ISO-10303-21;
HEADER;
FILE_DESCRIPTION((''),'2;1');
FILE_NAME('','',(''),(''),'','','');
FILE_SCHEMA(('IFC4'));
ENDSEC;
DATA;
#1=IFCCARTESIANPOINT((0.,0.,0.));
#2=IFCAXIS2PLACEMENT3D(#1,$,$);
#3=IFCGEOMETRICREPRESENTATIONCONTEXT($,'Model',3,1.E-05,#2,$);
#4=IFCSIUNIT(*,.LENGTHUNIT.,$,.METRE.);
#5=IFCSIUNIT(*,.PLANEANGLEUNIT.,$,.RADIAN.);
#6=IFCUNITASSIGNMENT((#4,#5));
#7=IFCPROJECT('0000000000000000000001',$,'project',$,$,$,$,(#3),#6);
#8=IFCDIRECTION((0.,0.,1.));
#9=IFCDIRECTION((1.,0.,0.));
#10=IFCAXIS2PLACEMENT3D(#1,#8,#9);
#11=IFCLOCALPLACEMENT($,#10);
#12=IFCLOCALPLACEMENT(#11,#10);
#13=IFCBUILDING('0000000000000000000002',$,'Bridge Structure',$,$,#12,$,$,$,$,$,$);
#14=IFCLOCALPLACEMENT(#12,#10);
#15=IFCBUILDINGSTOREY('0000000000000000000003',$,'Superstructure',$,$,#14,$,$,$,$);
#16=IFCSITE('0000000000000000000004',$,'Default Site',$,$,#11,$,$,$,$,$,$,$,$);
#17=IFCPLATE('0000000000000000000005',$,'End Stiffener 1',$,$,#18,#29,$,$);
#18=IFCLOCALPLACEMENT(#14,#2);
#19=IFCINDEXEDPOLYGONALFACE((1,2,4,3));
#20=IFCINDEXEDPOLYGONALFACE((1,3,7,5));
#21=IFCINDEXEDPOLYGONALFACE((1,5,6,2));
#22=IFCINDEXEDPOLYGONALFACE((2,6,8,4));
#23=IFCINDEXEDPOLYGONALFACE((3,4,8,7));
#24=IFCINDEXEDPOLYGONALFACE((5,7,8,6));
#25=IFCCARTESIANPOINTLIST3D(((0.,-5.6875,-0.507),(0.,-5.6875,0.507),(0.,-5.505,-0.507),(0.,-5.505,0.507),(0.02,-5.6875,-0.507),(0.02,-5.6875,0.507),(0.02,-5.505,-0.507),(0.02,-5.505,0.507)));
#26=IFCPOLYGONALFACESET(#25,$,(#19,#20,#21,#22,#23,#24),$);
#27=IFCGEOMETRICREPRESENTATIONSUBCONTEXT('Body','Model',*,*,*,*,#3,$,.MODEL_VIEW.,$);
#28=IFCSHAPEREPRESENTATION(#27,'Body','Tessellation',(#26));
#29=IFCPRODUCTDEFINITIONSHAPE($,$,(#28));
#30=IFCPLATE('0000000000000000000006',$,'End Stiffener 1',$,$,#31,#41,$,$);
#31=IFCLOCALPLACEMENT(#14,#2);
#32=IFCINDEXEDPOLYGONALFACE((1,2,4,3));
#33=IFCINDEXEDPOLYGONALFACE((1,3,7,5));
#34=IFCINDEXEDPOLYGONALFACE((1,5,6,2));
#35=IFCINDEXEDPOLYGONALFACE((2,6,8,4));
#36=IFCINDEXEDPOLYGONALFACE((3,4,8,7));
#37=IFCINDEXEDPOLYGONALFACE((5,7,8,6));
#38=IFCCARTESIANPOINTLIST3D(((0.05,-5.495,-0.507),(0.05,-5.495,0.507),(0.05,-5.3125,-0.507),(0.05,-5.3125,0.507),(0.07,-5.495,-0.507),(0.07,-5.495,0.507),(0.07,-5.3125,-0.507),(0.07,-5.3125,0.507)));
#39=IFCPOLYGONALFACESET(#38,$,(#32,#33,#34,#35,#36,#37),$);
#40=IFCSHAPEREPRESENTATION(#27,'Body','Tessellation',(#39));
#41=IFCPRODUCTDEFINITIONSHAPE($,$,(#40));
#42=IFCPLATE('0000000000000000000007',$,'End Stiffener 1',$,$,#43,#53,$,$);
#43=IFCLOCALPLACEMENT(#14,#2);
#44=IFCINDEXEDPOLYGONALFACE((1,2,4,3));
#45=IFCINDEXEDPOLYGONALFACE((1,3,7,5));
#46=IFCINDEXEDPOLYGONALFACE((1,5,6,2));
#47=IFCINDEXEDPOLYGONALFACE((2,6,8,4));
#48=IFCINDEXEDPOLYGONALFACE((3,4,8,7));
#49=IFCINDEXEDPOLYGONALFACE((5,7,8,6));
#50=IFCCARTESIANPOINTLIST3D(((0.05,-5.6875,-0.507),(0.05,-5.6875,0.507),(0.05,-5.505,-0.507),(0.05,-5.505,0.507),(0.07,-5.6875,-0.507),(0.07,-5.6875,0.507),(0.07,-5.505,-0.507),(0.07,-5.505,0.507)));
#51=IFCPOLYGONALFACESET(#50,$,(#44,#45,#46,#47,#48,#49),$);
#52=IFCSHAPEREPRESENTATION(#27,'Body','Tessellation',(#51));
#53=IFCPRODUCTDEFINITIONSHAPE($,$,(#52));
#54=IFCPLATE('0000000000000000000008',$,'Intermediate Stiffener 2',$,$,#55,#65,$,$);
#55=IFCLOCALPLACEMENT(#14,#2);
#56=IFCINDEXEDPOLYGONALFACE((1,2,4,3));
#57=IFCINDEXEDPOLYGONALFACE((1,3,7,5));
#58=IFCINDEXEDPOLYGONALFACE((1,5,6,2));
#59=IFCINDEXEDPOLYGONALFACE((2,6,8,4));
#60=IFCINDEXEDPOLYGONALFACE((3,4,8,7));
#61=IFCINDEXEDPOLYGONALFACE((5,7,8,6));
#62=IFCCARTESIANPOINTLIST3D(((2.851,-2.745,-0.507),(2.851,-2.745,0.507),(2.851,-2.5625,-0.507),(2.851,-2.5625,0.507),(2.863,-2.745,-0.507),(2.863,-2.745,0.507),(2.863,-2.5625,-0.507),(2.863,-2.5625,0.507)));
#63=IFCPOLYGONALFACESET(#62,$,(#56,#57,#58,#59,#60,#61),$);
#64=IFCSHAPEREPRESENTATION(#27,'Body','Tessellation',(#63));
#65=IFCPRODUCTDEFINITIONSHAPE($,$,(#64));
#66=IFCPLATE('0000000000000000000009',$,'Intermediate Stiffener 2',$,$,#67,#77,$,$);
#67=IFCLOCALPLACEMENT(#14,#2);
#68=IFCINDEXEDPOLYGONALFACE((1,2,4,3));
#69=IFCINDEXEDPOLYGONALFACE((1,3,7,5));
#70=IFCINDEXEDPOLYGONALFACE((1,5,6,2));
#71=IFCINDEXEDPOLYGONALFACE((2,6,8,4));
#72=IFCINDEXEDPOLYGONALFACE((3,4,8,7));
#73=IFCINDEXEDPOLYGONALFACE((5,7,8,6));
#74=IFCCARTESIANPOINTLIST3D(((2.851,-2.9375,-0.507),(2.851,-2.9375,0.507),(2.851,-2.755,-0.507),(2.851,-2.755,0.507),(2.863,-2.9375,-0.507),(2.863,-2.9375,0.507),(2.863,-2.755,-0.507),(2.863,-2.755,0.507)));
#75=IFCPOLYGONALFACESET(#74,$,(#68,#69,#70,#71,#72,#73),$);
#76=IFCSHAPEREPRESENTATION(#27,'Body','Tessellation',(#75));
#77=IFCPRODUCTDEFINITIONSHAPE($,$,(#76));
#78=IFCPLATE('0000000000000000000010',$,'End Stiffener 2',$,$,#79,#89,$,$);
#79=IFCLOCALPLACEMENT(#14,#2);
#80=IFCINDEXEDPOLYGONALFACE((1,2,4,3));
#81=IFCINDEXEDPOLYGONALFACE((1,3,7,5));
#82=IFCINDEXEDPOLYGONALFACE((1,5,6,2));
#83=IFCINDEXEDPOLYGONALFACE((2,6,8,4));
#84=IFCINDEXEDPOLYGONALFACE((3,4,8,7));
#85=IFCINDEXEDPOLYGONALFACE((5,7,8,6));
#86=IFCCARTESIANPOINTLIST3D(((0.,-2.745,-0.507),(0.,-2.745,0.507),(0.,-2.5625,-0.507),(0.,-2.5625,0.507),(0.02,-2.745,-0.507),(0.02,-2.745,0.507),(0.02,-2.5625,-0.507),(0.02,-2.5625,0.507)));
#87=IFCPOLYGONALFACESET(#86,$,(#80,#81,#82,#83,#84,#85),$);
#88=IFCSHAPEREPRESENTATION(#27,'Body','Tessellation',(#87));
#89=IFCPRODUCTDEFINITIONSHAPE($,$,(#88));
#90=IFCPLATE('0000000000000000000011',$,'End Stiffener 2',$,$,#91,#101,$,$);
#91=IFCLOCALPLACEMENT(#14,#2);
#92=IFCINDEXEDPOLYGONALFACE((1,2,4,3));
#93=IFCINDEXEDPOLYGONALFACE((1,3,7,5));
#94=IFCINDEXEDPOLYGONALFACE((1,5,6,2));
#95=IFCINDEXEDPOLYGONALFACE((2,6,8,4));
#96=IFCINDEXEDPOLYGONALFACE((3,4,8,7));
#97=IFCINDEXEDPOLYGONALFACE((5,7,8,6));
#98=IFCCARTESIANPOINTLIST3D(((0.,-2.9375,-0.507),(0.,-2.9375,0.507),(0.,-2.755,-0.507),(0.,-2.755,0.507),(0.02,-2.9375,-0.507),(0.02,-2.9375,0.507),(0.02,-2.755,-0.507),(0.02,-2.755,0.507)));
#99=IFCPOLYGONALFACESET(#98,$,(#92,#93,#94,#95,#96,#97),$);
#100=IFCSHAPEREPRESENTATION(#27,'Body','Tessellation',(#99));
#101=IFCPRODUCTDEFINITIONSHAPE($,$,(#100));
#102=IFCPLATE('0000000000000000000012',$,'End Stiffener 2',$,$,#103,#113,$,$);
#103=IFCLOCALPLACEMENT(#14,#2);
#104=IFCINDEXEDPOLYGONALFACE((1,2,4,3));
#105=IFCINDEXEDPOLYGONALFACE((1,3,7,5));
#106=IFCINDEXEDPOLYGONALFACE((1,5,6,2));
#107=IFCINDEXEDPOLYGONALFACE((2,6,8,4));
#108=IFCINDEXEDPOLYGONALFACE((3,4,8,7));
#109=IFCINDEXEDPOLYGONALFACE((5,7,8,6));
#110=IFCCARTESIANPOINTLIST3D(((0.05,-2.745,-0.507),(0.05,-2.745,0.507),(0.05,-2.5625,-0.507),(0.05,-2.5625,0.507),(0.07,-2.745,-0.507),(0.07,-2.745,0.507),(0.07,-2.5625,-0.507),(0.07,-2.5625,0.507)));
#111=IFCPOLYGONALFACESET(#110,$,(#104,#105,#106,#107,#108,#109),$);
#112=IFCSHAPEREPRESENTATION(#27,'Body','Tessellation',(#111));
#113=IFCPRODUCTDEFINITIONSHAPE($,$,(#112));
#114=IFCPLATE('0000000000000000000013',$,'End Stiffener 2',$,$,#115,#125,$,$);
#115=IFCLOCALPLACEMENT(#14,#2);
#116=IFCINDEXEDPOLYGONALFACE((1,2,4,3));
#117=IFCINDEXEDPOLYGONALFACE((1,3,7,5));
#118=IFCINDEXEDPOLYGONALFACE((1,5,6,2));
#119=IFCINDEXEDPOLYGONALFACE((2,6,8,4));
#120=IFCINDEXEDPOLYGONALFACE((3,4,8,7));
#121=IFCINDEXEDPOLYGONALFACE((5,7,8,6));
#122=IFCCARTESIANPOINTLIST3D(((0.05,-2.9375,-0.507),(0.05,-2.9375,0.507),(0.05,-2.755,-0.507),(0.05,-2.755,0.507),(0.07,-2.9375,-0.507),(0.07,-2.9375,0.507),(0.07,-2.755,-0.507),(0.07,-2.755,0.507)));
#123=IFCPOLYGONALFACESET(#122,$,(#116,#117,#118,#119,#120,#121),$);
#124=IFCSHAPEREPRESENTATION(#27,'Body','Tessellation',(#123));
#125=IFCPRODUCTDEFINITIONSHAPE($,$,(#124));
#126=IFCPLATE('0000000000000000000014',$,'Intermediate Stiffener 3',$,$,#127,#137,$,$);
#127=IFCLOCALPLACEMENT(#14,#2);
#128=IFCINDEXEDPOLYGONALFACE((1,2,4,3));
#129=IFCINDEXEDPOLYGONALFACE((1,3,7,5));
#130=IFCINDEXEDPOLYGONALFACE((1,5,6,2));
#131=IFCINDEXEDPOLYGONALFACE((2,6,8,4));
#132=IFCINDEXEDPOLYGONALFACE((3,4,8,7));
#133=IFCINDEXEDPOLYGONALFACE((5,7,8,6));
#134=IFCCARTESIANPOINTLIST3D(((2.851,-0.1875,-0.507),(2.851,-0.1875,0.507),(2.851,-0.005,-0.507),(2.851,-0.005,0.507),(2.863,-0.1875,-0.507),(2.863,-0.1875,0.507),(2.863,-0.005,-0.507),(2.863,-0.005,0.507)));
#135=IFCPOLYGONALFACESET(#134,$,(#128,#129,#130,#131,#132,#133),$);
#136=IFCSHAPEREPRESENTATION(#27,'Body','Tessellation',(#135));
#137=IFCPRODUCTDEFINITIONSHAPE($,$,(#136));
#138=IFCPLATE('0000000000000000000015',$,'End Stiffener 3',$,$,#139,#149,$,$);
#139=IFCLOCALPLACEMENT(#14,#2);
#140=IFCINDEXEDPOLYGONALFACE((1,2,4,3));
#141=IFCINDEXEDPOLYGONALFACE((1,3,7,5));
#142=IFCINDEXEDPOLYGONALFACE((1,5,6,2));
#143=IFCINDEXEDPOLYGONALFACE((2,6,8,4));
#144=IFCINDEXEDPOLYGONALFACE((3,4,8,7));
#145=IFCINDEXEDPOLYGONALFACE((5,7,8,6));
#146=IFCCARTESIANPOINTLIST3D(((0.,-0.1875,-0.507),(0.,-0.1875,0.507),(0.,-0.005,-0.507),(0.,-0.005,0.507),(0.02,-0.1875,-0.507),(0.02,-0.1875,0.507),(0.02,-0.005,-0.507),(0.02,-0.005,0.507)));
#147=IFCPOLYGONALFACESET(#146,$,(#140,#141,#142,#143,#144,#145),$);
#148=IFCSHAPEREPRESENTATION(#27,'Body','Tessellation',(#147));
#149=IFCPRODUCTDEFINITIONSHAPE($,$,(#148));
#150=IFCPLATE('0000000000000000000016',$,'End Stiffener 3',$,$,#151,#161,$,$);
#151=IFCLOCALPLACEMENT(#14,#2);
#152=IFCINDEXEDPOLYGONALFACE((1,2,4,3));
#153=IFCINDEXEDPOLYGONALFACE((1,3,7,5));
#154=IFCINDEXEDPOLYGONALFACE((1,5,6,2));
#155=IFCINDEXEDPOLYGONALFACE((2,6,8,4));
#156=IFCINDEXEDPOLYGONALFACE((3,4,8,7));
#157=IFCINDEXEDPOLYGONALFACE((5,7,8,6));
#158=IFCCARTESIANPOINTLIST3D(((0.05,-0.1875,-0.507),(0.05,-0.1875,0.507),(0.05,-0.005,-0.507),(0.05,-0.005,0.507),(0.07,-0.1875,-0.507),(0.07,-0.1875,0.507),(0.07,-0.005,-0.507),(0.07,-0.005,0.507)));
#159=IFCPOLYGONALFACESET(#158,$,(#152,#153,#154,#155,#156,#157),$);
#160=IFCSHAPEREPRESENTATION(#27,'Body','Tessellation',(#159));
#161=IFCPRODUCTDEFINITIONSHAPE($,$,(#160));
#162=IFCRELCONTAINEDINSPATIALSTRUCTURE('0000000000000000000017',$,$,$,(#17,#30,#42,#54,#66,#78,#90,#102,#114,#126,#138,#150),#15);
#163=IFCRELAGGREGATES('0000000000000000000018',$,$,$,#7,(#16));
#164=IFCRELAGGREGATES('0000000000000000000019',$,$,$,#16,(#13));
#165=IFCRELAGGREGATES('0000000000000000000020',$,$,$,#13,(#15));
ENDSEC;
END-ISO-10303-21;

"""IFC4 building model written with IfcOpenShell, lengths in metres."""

from ifc_helpers import new_model, si_unit, frame, origin, origin_with_axes, origin_2d_with_axis, place, context, subcontext, project, spatial, rectangle, extrude, element, save


model = new_model("IFC4")

# Units and contexts
model_context = context("Model", 3, precision=1e-05, world=origin())
body_context = subcontext(model_context, "Body", "Model", "MODEL_VIEW")
ifc_project = project(units=[si_unit("LENGTHUNIT", "METRE"), si_unit("PLANEANGLEUNIT", "RADIAN")], contexts=[model_context])

# Site, building, storey
site_placement = place(None, origin_with_axes())
site = spatial("IfcSite", under=ifc_project, at=site_placement, Name="Default Site")
building_placement = place(site_placement, origin_with_axes())
building = spatial("IfcBuilding", under=site, at=building_placement, Name="Bridge Structure")
storey_placement = place(building_placement, origin_with_axes())
storey = spatial("IfcBuildingStorey", under=building, at=storey_placement, Name="Superstructure")

# Plates
for number, where, z_axis, x_axis, name in (
    (1, (0.01, -5.5963, -0.507), (0.0, 0.0, 1.0), (1.0, 0.0, 0.0), "End Stiffener 1"),
    (2, (0.06, -5.4038, -0.507), (0.0, 0.0, 1.0), (1.0, 0.0, 0.0), "End Stiffener 1"),
    (3, (0.06, -5.5963, -0.507), (0.0, 0.0, 1.0), (1.0, 0.0, 0.0), "End Stiffener 1"),
):
    element("IfcPlate", number, at=place(storey_placement, frame(where, z_axis=z_axis, x_axis=x_axis)), inside=storey, Name=name, context=body_context, shape_type="SweptSolid", body=[
        extrude(rectangle(XDim=0.02, YDim=0.1825, at=origin_2d_with_axis()), origin_with_axes(), (0.0, 0.0, 1.0), 1.014),
    ])
for number, where, z_axis, x_axis, name in (
    (4, (2.857, -2.6538, -0.507), (0.0, 0.0, 1.0), (1.0, 0.0, 0.0), "Intermediate Stiffener 2"),
    (5, (2.857, -2.8462, -0.507), (0.0, 0.0, 1.0), (1.0, 0.0, 0.0), "Intermediate Stiffener 2"),
):
    element("IfcPlate", number, at=place(storey_placement, frame(where, z_axis=z_axis, x_axis=x_axis)), inside=storey, Name=name, context=body_context, shape_type="SweptSolid", body=[
        extrude(rectangle(XDim=0.012, YDim=0.1825, at=origin_2d_with_axis()), origin_with_axes(), (0.0, 0.0, 1.0), 1.014),
    ])
for number, where, z_axis, x_axis, name in (
    (6, (0.01, -2.6538, -0.507), (0.0, 0.0, 1.0), (1.0, 0.0, 0.0), "End Stiffener 2"),
    (7, (0.01, -2.8462, -0.507), (0.0, 0.0, 1.0), (1.0, 0.0, 0.0), "End Stiffener 2"),
    (8, (0.06, -2.6538, -0.507), (0.0, 0.0, 1.0), (1.0, 0.0, 0.0), "End Stiffener 2"),
    (9, (0.06, -2.8462, -0.507), (0.0, 0.0, 1.0), (1.0, 0.0, 0.0), "End Stiffener 2"),
):
    element("IfcPlate", number, at=place(storey_placement, frame(where, z_axis=z_axis, x_axis=x_axis)), inside=storey, Name=name, context=body_context, shape_type="SweptSolid", body=[
        extrude(rectangle(XDim=0.02, YDim=0.1825, at=origin_2d_with_axis()), origin_with_axes(), (0.0, 0.0, 1.0), 1.014),
    ])
plate_1_placement = place(storey_placement, frame((2.857, -0.0963, -0.507), z_axis=(0.0, 0.0, 1.0), x_axis=(1.0, 0.0, 0.0)))
element("IfcPlate", 10, at=plate_1_placement, inside=storey, Name="Intermediate Stiffener 3", context=body_context, shape_type="SweptSolid", body=[
    extrude(rectangle(XDim=0.012, YDim=0.1825, at=origin_2d_with_axis()), origin_with_axes(), (0.0, 0.0, 1.0), 1.014),
])
for number, where, z_axis, x_axis, name in (
    (11, (0.01, -0.0963, -0.507), (0.0, 0.0, 1.0), (1.0, 0.0, 0.0), "End Stiffener 3"),
    (12, (0.06, -0.0963, -0.507), (0.0, 0.0, 1.0), (1.0, 0.0, 0.0), "End Stiffener 3"),
):
    element("IfcPlate", number, at=place(storey_placement, frame(where, z_axis=z_axis, x_axis=x_axis)), inside=storey, Name=name, context=body_context, shape_type="SweptSolid", body=[
        extrude(rectangle(XDim=0.02, YDim=0.1825, at=origin_2d_with_axis()), origin_with_axes(), (0.0, 0.0, 1.0), 1.014),
    ])

save(model, "model.ifc")
